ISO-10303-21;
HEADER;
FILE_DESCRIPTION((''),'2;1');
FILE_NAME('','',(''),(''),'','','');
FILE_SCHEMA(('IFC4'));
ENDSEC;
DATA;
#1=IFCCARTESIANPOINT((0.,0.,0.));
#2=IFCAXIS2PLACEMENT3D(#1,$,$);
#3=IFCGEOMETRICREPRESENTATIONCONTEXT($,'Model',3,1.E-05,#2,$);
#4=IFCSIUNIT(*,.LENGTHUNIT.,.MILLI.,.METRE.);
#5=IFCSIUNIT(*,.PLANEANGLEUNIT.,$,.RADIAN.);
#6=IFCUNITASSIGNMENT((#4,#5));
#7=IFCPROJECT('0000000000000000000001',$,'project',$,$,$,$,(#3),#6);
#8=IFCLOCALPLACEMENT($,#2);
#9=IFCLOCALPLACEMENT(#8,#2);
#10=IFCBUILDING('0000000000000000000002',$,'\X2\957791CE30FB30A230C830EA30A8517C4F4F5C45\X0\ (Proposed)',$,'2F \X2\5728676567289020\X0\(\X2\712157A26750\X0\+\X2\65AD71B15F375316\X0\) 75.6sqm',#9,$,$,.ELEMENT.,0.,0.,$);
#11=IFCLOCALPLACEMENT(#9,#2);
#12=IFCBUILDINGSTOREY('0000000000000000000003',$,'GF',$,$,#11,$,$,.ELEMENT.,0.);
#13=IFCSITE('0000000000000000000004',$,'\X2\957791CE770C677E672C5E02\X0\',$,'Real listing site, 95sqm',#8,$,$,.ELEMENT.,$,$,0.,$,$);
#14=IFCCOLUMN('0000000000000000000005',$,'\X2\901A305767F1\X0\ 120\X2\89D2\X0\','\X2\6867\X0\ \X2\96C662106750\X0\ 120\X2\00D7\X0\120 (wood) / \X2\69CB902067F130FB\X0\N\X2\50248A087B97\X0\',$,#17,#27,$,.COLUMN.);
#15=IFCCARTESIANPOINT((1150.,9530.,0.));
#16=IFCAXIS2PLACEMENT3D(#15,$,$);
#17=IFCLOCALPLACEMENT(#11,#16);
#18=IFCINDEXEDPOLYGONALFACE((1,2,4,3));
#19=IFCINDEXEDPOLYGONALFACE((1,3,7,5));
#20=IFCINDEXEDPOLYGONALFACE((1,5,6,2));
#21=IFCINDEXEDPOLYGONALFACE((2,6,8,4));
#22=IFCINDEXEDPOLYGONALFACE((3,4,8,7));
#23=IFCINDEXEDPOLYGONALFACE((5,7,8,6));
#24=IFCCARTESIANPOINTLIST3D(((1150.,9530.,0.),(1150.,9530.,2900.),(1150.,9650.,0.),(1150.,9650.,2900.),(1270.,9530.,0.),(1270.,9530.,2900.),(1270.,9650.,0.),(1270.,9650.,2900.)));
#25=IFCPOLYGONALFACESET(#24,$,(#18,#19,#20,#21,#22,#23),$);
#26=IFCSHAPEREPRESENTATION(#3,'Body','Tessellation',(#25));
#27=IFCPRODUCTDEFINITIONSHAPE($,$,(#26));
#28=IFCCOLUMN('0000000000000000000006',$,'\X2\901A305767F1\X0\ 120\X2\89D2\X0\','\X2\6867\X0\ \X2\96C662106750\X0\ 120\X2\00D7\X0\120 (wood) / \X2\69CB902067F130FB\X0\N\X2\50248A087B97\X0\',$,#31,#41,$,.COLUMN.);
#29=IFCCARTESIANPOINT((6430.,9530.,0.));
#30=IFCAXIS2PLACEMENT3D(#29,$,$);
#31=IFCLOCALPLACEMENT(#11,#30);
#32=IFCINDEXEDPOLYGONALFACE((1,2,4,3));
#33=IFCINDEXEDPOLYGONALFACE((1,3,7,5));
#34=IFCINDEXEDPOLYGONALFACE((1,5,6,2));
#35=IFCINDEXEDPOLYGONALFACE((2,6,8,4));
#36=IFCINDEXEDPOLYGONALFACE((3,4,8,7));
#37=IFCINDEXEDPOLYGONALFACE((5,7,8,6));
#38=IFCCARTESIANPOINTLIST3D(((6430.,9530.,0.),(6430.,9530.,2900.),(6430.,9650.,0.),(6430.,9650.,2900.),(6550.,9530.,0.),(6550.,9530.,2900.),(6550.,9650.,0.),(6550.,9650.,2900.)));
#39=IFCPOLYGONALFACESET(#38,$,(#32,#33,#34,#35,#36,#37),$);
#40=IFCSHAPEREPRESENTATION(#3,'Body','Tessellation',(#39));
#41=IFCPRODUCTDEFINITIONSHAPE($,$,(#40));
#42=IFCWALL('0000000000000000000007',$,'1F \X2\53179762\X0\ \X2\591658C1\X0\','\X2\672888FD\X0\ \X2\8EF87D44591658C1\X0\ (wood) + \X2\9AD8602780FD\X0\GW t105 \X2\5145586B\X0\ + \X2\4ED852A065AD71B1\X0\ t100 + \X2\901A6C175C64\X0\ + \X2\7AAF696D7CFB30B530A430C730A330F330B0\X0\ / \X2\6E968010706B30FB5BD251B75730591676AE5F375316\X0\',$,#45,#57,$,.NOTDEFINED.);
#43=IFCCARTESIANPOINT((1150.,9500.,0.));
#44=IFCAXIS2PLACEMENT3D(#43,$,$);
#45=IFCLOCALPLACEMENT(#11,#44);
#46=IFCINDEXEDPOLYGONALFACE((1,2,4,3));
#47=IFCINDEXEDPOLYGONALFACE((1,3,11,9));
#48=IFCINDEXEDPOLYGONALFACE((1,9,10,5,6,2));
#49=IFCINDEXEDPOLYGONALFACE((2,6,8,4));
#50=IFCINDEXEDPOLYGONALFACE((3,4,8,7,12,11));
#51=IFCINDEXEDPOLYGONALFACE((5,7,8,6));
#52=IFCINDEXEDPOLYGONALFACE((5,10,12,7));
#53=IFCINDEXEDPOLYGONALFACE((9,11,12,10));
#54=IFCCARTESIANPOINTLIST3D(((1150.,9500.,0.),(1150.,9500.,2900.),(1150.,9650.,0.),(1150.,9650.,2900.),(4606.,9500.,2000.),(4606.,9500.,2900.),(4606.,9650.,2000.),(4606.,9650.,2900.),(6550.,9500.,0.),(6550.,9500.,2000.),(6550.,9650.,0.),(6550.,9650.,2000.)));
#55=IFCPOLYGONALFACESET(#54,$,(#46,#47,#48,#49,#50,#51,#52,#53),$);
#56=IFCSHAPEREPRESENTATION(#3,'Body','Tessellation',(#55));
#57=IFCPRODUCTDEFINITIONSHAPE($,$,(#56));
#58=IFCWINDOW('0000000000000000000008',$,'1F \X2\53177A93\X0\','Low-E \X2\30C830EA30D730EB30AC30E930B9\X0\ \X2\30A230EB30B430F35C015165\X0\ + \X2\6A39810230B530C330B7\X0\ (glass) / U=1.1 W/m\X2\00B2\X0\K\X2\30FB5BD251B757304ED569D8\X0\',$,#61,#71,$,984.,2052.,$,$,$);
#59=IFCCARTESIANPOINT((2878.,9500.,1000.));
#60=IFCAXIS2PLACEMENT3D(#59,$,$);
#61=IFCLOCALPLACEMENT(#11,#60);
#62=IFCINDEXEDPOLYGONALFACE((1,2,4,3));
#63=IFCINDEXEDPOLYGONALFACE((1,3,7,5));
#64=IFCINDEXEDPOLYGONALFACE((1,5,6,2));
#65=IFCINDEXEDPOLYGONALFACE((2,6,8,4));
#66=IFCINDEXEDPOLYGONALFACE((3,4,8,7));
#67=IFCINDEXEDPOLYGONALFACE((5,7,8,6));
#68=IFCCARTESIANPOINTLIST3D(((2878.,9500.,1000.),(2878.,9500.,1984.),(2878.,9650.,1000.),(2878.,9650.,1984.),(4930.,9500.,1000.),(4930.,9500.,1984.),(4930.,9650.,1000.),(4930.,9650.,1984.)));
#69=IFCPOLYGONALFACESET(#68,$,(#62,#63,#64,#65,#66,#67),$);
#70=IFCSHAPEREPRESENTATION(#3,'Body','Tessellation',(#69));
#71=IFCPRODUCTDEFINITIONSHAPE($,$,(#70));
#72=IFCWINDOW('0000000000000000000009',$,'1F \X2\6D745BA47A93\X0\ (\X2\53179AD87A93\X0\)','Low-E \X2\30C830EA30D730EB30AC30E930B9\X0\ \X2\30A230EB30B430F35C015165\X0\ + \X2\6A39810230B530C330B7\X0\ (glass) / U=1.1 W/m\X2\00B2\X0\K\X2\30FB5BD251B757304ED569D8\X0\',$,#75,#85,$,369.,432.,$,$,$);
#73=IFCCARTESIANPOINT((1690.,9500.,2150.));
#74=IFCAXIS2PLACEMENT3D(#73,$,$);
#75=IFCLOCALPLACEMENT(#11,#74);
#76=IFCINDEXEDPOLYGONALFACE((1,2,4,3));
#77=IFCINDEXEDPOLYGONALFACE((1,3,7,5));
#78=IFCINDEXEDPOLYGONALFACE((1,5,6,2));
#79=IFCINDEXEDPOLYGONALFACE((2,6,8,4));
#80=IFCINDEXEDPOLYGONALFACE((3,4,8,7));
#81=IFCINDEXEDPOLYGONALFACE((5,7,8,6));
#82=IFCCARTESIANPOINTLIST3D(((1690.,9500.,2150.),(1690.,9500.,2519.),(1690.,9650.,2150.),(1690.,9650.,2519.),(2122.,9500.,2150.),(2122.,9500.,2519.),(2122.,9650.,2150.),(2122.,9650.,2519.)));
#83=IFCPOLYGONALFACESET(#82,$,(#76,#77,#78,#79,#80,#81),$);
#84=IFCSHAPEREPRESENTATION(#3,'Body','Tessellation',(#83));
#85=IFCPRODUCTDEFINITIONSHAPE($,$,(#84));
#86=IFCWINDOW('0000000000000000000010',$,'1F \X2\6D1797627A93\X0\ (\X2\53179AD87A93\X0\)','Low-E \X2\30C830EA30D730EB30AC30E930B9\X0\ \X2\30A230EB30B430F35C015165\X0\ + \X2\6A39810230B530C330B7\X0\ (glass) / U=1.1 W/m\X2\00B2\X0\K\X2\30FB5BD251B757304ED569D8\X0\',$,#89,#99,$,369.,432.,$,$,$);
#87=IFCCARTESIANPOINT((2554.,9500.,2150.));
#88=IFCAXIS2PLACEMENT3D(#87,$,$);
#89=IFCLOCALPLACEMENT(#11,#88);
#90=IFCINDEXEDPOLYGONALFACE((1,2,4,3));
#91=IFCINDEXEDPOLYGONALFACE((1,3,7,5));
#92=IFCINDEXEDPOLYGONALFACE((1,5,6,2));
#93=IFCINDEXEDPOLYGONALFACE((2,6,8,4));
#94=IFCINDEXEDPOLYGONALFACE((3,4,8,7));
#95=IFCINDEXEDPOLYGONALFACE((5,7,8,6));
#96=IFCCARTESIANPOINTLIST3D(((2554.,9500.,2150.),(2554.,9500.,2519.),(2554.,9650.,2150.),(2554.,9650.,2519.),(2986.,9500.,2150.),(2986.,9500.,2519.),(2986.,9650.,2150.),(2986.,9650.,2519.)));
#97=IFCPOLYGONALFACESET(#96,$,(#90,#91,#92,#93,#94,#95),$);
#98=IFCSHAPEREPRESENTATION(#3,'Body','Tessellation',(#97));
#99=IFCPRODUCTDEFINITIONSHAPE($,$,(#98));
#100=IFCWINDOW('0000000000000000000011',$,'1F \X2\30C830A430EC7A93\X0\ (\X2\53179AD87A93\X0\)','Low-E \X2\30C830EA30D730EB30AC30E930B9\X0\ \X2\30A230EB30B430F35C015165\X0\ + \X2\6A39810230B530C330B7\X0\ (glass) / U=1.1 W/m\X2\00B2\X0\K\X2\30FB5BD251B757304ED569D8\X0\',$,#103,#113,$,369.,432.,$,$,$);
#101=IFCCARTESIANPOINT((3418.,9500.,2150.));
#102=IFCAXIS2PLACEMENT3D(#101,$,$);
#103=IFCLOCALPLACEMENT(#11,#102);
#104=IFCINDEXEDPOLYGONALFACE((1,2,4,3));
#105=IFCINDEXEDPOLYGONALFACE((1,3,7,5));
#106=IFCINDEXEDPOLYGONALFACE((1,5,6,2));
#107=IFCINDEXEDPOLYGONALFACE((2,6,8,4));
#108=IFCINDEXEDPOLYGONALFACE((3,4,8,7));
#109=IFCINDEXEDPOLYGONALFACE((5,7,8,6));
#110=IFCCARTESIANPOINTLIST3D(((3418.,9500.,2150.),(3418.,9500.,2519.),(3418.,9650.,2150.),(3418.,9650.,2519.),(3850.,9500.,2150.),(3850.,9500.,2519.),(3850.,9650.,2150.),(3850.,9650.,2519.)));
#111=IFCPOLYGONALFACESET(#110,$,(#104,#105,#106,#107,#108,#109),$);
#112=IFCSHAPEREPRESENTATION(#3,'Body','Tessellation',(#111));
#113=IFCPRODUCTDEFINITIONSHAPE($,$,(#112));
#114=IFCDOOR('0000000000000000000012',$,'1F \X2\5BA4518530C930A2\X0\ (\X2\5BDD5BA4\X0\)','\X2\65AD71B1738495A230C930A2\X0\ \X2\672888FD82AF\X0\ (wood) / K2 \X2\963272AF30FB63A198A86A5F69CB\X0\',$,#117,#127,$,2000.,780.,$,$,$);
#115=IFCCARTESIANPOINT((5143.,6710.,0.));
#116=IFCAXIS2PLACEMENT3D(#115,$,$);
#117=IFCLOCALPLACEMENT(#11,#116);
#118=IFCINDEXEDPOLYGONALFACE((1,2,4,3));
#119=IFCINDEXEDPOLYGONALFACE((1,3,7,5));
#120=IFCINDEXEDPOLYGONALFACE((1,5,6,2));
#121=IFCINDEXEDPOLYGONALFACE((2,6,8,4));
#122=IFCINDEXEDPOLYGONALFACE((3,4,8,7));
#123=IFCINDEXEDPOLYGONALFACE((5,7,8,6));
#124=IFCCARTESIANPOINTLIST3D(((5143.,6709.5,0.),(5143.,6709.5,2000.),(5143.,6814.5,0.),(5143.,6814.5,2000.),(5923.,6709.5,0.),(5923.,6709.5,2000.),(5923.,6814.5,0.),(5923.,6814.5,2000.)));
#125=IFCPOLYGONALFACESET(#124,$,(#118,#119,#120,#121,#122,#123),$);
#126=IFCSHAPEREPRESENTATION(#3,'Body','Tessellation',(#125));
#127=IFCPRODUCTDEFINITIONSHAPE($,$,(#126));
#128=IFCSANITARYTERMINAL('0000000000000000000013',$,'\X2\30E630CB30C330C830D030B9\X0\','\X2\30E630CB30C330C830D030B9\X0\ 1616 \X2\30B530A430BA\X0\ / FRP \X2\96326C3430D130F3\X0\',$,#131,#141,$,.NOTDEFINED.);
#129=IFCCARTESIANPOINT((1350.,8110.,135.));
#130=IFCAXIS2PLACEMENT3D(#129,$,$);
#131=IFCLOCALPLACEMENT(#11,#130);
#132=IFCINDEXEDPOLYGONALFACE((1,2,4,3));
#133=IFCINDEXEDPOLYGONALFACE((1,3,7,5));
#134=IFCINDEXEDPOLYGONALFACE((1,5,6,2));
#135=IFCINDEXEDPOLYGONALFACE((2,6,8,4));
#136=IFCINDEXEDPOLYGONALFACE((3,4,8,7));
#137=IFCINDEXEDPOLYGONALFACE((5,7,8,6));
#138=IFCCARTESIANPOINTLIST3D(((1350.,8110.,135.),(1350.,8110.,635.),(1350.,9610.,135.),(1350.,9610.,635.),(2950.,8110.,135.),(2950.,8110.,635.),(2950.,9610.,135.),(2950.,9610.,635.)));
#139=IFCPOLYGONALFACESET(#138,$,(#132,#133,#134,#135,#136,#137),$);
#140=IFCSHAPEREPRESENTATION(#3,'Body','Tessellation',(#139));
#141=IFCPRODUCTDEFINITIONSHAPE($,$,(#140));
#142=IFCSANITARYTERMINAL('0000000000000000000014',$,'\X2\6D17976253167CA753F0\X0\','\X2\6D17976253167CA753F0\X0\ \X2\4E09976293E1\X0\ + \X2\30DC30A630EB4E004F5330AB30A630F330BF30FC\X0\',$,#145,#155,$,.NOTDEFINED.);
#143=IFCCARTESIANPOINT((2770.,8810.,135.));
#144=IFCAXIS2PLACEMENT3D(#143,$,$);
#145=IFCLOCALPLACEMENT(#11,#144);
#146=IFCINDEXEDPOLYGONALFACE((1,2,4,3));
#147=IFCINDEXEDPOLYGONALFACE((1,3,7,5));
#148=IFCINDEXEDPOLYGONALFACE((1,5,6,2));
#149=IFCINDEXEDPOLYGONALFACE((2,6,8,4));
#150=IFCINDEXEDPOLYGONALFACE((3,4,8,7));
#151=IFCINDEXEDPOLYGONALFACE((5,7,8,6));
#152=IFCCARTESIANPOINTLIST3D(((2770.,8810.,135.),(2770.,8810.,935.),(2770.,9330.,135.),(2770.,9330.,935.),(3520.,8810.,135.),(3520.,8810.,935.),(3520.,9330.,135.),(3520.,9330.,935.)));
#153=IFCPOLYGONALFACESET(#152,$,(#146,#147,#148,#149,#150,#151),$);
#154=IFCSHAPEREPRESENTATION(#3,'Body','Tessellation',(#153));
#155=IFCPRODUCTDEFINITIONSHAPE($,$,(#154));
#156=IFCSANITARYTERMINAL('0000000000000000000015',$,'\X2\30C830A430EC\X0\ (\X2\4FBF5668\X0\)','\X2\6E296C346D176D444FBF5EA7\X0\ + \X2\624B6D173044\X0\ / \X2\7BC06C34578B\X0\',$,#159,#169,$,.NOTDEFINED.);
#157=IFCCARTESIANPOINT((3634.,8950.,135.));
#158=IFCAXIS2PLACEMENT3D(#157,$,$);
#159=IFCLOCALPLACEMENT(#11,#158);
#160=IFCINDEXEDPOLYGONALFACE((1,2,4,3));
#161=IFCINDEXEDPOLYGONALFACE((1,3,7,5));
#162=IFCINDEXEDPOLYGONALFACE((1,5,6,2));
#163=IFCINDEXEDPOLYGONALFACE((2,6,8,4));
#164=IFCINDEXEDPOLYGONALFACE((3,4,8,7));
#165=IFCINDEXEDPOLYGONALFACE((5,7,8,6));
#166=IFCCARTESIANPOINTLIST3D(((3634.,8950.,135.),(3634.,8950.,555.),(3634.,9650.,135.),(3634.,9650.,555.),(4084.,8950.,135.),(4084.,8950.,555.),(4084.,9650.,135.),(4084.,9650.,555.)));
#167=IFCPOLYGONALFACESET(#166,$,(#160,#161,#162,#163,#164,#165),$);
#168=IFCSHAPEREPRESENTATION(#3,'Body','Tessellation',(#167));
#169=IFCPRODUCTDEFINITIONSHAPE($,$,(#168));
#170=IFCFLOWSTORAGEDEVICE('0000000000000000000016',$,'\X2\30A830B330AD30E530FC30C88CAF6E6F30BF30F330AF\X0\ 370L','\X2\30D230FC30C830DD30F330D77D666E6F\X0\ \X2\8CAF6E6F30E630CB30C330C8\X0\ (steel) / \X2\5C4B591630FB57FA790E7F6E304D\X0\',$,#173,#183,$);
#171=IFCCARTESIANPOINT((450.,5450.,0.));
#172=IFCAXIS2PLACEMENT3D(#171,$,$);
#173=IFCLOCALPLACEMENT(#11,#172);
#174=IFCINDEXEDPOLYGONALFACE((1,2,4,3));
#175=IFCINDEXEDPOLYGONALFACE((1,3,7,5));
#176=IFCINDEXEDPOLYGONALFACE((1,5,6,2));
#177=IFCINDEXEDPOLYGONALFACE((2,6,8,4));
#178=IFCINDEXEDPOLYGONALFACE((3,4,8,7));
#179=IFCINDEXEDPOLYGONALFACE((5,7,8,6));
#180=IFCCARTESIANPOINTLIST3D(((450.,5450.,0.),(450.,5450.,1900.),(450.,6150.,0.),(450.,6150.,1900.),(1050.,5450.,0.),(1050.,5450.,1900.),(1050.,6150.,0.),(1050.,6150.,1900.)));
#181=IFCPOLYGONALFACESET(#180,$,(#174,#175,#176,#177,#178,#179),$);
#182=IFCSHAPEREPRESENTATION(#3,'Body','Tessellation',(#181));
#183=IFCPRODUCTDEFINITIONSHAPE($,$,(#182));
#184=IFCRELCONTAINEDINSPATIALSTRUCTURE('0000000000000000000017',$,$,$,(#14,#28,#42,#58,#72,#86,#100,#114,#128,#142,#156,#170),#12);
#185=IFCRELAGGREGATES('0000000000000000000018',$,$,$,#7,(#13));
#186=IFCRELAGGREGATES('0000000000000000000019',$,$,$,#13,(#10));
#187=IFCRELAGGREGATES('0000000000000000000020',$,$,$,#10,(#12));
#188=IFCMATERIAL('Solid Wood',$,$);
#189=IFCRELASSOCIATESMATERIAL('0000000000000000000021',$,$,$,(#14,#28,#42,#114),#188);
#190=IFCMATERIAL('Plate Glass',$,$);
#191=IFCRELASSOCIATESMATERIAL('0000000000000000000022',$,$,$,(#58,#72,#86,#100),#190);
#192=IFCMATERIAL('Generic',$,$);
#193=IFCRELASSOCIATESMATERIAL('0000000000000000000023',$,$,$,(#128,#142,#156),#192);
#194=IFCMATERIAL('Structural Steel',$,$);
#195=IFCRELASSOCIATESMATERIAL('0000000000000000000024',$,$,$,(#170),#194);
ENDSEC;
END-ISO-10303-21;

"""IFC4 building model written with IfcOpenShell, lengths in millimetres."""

from ifc_helpers import new_model, si_unit, frame, frame_2d, origin, place, context, project, spatial, rectangle, extrude, material, element, fill, save


model = new_model("IFC4")

# Units and contexts
model_context = context("Model", 3, precision=1e-05, world=origin())
ifc_project = project(units=[si_unit("LENGTHUNIT", "METRE", prefix="MILLI"), si_unit("PLANEANGLEUNIT", "RADIAN")], contexts=[model_context])

# Site, building, storey
site_placement = place(None, origin())
site = spatial("IfcSite", under=ifc_project, at=site_placement, Name="長野県松本市", ObjectType="Real listing site, 95sqm", CompositionType="ELEMENT", RefElevation=0.0)
building_placement = place(site_placement, origin())
building = spatial("IfcBuilding", under=site, at=building_placement, Name="長野・アトリエ兼住居 (Proposed)", ObjectType="2F 在来木造(無垢材+断熱強化) 75.6sqm", CompositionType="ELEMENT", ElevationOfRefHeight=0.0, ElevationOfTerrain=0.0)
storey_placement = place(building_placement, origin())
storey = spatial("IfcBuildingStorey", under=building, at=storey_placement, Name="GF", CompositionType="ELEMENT", Elevation=0.0)

# Columns
ifc_material_1 = material(Name="Solid Wood")
column_1_placement = place(storey_placement, frame((1150.0, 9530.0, 0.0)))
element("IfcColumn", 1, at=column_1_placement, inside=storey, material=ifc_material_1, Name="通し柱 120角", Description="桧 集成材 120×120 (wood) / 構造柱・N値計算", PredefinedType="COLUMN", context=model_context, shape_type="SweptSolid", body=[
    extrude(rectangle(XDim=120.0, YDim=120.0, at=frame_2d((60.0, 60.0))), frame((1150.0, 9530.0, 0.0)), (0.0, 0.0, 1.0), 2900.0),
])
column_2_placement = place(storey_placement, frame((6430.0, 9530.0, 0.0)))
element("IfcColumn", 2, at=column_2_placement, inside=storey, material=ifc_material_1, Name="通し柱 120角", Description="桧 集成材 120×120 (wood) / 構造柱・N値計算", PredefinedType="COLUMN", context=model_context, shape_type="SweptSolid", body=[
    extrude(rectangle(XDim=120.0, YDim=120.0, at=frame_2d((60.0, 60.0))), frame((6430.0, 9530.0, 0.0)), (0.0, 0.0, 1.0), 2900.0),
])

# Wall, openings, windows
wall_1_placement = place(storey_placement, frame((1150.0, 9500.0, 0.0)))
wall_1 = element("IfcWall", 3, at=wall_1_placement, inside=storey, material=ifc_material_1, Name="1F 北面 外壁", Description="木製 軸組外壁 (wood) + 高性能GW t105 充填 + 付加断熱 t100 + 通気層 + 窯業系サイディング / 準耐火・寒冷地外皮強化", PredefinedType="NOTDEFINED", context=model_context, shape_type="SweptSolid", body=[
    extrude(rectangle(XDim=5400.0, YDim=150.0, at=frame_2d((2700.0, 75.0))), frame((1150.0, 9500.0, 0.0)), (0.0, 0.0, 1.0), 2900.0),
])
opening_1_placement = place(storey_placement, frame((2878.0, 9500.0, 1000.0)))
opening_1 = element("IfcOpeningElement", 4, at=opening_1_placement, cuts=wall_1, PredefinedType="NOTDEFINED", context=model_context, shape_type="SweptSolid", body=[
    extrude(rectangle(XDim=2052.0, YDim=150.0, at=frame_2d((1026.0, 75.0))), frame((2878.0, 9500.0, 1000.0)), (0.0, 0.0, 1.0), 984.0),
])
opening_2_placement = place(storey_placement, frame((1690.0, 9500.0, 2150.0)))
opening_2 = element("IfcOpeningElement", 5, at=opening_2_placement, cuts=wall_1, PredefinedType="NOTDEFINED", context=model_context, shape_type="SweptSolid", body=[
    extrude(rectangle(XDim=432.0, YDim=150.0, at=frame_2d((216.0, 75.0))), frame((1690.0, 9500.0, 2150.0)), (0.0, 0.0, 1.0), 369.0),
])
opening_3_placement = place(storey_placement, frame((2554.0, 9500.0, 2150.0)))
opening_3 = element("IfcOpeningElement", 6, at=opening_3_placement, cuts=wall_1, PredefinedType="NOTDEFINED", context=model_context, shape_type="SweptSolid", body=[
    extrude(rectangle(XDim=432.0, YDim=150.0, at=frame_2d((216.0, 75.0))), frame((2554.0, 9500.0, 2150.0)), (0.0, 0.0, 1.0), 369.0),
])
opening_4_placement = place(storey_placement, frame((3418.0, 9500.0, 2150.0)))
opening_4 = element("IfcOpeningElement", 7, at=opening_4_placement, cuts=wall_1, PredefinedType="NOTDEFINED", context=model_context, shape_type="SweptSolid", body=[
    extrude(rectangle(XDim=432.0, YDim=150.0, at=frame_2d((216.0, 75.0))), frame((3418.0, 9500.0, 2150.0)), (0.0, 0.0, 1.0), 369.0),
])
ifc_material_2 = material(Name="Plate Glass")
window_1_placement = place(storey_placement, frame((2878.0, 9500.0, 1000.0)))
window_1 = element("IfcWindow", 8, at=window_1_placement, inside=storey, material=ifc_material_2, Name="1F 北窓", Description="Low-E トリプルガラス アルゴン封入 + 樹脂サッシ (glass) / U=1.1 W/m²K・寒冷地仕様", OverallHeight=984.0, OverallWidth=2052.0, context=model_context, shape_type="SweptSolid", body=[
    extrude(rectangle(XDim=2052.0, YDim=150.0, at=frame_2d((1026.0, 75.0))), frame((2878.0, 9500.0, 1000.0)), (0.0, 0.0, 1.0), 984.0),
])
fill(opening_1, window_1)
window_2_placement = place(storey_placement, frame((1690.0, 9500.0, 2150.0)))
window_2 = element("IfcWindow", 9, at=window_2_placement, inside=storey, material=ifc_material_2, Name="1F 浴室窓 (北高窓)", Description="Low-E トリプルガラス アルゴン封入 + 樹脂サッシ (glass) / U=1.1 W/m²K・寒冷地仕様", OverallHeight=369.0, OverallWidth=432.0, context=model_context, shape_type="SweptSolid", body=[
    extrude(rectangle(XDim=432.0, YDim=150.0, at=frame_2d((216.0, 75.0))), frame((1690.0, 9500.0, 2150.0)), (0.0, 0.0, 1.0), 369.0),
])
fill(opening_2, window_2)
window_3_placement = place(storey_placement, frame((2554.0, 9500.0, 2150.0)))
window_3 = element("IfcWindow", 10, at=window_3_placement, inside=storey, material=ifc_material_2, Name="1F 洗面窓 (北高窓)", Description="Low-E トリプルガラス アルゴン封入 + 樹脂サッシ (glass) / U=1.1 W/m²K・寒冷地仕様", OverallHeight=369.0, OverallWidth=432.0, context=model_context, shape_type="SweptSolid", body=[
    extrude(rectangle(XDim=432.0, YDim=150.0, at=frame_2d((216.0, 75.0))), frame((2554.0, 9500.0, 2150.0)), (0.0, 0.0, 1.0), 369.0),
])
fill(opening_3, window_3)
window_4_placement = place(storey_placement, frame((3418.0, 9500.0, 2150.0)))
window_4 = element("IfcWindow", 11, at=window_4_placement, inside=storey, material=ifc_material_2, Name="1F トイレ窓 (北高窓)", Description="Low-E トリプルガラス アルゴン封入 + 樹脂サッシ (glass) / U=1.1 W/m²K・寒冷地仕様", OverallHeight=369.0, OverallWidth=432.0, context=model_context, shape_type="SweptSolid", body=[
    extrude(rectangle(XDim=432.0, YDim=150.0, at=frame_2d((216.0, 75.0))), frame((3418.0, 9500.0, 2150.0)), (0.0, 0.0, 1.0), 369.0),
])
fill(opening_4, window_4)

# Door
door_1_placement = place(storey_placement, frame((5143.0, 6710.0, 0.0)))
element("IfcDoor", 12, at=door_1_placement, inside=storey, material=ifc_material_1, Name="1F 室内ドア (寝室)", Description="断熱玄関ドア 木製芯 (wood) / K2 防犯・採風機構", OverallHeight=2000.0, OverallWidth=780.0, context=model_context, shape_type="SweptSolid", body=[
    extrude(rectangle(XDim=780.0, YDim=105.0, at=frame_2d((390.0, 52.0))), frame((5143.0, 6710.0, 0.0)), (0.0, 0.0, 1.0), 2000.0),
])

# Sanitary terminals
ifc_material_3 = material(Name="Generic")
sanitary_terminal_1_placement = place(storey_placement, frame((1350.0, 8110.0, 135.0)))
element("IfcSanitaryTerminal", 13, at=sanitary_terminal_1_placement, inside=storey, material=ifc_material_3, Name="ユニットバス", Description="ユニットバス 1616 サイズ / FRP 防水パン", PredefinedType="NOTDEFINED", context=model_context, shape_type="SweptSolid", body=[
    extrude(rectangle(XDim=1600.0, YDim=1500.0, at=frame_2d((800.0, 750.0))), frame((1350.0, 8110.0, 135.0)), (0.0, 0.0, 1.0), 500.0),
])
sanitary_terminal_2_placement = place(storey_placement, frame((2770.0, 8810.0, 135.0)))
element("IfcSanitaryTerminal", 14, at=sanitary_terminal_2_placement, inside=storey, material=ifc_material_3, Name="洗面化粧台", Description="洗面化粧台 三面鏡 + ボウル一体カウンター", PredefinedType="NOTDEFINED", context=model_context, shape_type="SweptSolid", body=[
    extrude(rectangle(XDim=750.0, YDim=520.0, at=frame_2d((375.0, 260.0))), frame((2770.0, 8810.0, 135.0)), (0.0, 0.0, 1.0), 800.0),
])
sanitary_terminal_3_placement = place(storey_placement, frame((3634.0, 8950.0, 135.0)))
element("IfcSanitaryTerminal", 15, at=sanitary_terminal_3_placement, inside=storey, material=ifc_material_3, Name="トイレ (便器)", Description="温水洗浄便座 + 手洗い / 節水型", PredefinedType="NOTDEFINED", context=model_context, shape_type="SweptSolid", body=[
    extrude(rectangle(XDim=450.0, YDim=700.0, at=frame_2d((225.0, 350.0))), frame((3634.0, 8950.0, 135.0)), (0.0, 0.0, 1.0), 420.0),
])

# Flow storage device
ifc_material_4 = material(Name="Structural Steel")
flow_storage_device_placement = place(storey_placement, frame((450.0, 5450.0, 0.0)))
element("IfcFlowStorageDevice", 16, at=flow_storage_device_placement, inside=storey, material=ifc_material_4, Name="エコキュート貯湯タンク 370L", Description="ヒートポンプ給湯 貯湯ユニット (steel) / 屋外・基礎置き", context=model_context, shape_type="SweptSolid", body=[
    extrude(rectangle(XDim=600.0, YDim=700.0, at=frame_2d((300.0, 350.0))), frame((450.0, 5450.0, 0.0)), (0.0, 0.0, 1.0), 1900.0),
])

save(model, "model.ifc")
